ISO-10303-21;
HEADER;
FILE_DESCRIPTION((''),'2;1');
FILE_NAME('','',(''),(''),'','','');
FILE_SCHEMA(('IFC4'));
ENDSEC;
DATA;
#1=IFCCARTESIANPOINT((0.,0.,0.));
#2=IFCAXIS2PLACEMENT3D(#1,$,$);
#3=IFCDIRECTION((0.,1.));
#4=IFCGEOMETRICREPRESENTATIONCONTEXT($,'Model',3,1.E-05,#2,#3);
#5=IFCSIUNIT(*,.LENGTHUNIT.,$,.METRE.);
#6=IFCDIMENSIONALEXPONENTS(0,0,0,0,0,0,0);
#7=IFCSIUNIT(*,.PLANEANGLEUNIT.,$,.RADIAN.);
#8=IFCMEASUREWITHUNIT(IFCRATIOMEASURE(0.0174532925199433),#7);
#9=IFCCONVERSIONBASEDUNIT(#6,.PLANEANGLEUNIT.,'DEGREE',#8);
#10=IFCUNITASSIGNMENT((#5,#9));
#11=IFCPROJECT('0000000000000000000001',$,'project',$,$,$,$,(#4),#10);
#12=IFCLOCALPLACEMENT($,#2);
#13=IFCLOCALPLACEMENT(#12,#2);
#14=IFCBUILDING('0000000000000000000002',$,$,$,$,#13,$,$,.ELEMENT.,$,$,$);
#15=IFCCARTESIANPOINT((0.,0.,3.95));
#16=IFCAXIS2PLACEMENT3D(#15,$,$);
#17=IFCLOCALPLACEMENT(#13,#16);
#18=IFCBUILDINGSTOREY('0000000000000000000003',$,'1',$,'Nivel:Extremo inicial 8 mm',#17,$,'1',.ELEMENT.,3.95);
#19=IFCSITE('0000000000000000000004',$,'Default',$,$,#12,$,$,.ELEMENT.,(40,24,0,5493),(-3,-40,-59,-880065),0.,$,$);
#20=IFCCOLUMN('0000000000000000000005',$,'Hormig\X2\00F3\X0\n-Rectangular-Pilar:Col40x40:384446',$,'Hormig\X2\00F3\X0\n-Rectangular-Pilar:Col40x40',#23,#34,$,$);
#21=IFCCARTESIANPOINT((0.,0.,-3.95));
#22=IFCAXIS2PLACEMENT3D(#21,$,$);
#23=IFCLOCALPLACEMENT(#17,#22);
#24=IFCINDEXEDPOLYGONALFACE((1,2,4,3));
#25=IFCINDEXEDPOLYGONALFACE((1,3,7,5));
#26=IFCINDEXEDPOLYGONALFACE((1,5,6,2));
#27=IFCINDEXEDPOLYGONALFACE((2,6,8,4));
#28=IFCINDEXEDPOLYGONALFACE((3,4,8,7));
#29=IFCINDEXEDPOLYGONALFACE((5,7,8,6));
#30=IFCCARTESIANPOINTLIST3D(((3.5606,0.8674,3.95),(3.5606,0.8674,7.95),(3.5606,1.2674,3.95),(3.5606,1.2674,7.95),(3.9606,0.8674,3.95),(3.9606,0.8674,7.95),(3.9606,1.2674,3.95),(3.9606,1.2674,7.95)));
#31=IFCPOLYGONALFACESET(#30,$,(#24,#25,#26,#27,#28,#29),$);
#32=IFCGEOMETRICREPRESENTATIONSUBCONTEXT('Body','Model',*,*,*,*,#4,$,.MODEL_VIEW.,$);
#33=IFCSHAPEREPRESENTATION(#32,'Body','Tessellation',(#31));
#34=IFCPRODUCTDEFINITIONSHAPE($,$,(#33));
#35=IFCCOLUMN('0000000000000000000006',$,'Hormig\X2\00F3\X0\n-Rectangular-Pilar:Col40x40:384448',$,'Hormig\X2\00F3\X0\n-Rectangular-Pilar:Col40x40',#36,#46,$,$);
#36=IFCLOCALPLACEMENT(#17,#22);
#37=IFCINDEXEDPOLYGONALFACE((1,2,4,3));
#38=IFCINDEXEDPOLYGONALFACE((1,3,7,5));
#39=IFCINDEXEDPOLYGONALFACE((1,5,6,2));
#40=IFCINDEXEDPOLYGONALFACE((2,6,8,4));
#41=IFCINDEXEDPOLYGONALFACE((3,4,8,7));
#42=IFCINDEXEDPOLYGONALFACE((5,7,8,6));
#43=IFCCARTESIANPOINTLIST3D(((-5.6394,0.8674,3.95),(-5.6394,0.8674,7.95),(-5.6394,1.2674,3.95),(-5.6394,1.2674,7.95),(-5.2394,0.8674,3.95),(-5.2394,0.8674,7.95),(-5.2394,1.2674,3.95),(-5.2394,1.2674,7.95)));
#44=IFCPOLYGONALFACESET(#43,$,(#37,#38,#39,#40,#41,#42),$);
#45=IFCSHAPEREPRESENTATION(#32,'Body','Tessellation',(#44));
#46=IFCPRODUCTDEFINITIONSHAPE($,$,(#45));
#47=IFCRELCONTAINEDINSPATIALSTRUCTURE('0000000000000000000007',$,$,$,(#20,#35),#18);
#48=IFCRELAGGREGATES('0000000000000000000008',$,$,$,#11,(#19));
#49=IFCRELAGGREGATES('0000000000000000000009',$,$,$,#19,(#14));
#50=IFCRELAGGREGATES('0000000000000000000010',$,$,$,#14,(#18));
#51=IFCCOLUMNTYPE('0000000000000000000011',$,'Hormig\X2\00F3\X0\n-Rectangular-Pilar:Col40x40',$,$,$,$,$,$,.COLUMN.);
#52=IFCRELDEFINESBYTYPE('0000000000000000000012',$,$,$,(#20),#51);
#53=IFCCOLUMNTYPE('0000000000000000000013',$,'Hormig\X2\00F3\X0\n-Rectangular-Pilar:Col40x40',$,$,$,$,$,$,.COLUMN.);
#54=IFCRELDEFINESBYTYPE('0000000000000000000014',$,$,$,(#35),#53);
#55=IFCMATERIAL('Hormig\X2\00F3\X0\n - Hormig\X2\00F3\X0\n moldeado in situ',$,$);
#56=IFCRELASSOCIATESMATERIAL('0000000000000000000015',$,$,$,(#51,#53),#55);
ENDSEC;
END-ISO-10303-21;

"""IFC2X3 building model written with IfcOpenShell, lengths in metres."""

from ifc_helpers import new_model, entity, si_unit, converted_unit, direction, frame, origin, origin_2d_with_axis, place, context, subcontext, project, spatial, rectangle, extrude, source, transform, mapped, material, type_object, type_shapes, element, save


model = new_model("IFC2X3")

# Units and contexts
model_context = context("Model", 3, precision=1e-05, world=origin(), true_north=direction((0.0, 1.0)))
body_context = subcontext(model_context, "Body", "Model", "MODEL_VIEW")
ifc_project = project(units=[si_unit("LENGTHUNIT", "METRE"), converted_unit("PLANEANGLEUNIT", "DEGREE", entity("IfcRatioMeasure", 0.0174532925199433), si_unit("PLANEANGLEUNIT", "RADIAN"), dimensions=[0, 0, 0, 0, 0, 0, 0])], contexts=[model_context])

# Site, building, storey
site_placement = place(None, origin())
site = spatial("IfcSite", under=ifc_project, at=site_placement, Name="Default", CompositionType="ELEMENT", RefLatitude=(40, 24, 0, 5493), RefLongitude=(-3, -40, -59, -880065), RefElevation=0.0)
building_placement = place(site_placement, origin())
building = spatial("IfcBuilding", under=site, at=building_placement, CompositionType="ELEMENT")
storey_placement = place(building_placement, frame((0.0, 0.0, 3.95)))
storey = spatial("IfcBuildingStorey", under=building, at=storey_placement, Name="1", ObjectType="Nivel:Extremo inicial 8 mm", LongName="1", CompositionType="ELEMENT", Elevation=3.95)

# Columns
ifc_material_1 = material(Name="Hormigón - Hormigón moldeado in situ")
column_type_1 = type_object("IfcColumnType", Name="Hormigón-Rectangular-Pilar:Col40x40", PredefinedType="COLUMN", material=ifc_material_1)
shared_shape_1 = source(origin(), body_context, "Body", "SweptSolid", [
    extrude(rectangle(XDim=0.4, YDim=0.4, at=origin_2d_with_axis()), frame((3.7606, 1.0674, 3.95), z_axis=(0.0, 0.0, 1.0), x_axis=(0.0, -1.0, 0.0)), (0.0, 0.0, 1.0), 4.0),
])
type_shapes(column_type_1, [shared_shape_1])
column_1_placement = place(storey_placement, frame((0.0, 0.0, -3.95)))
element("IfcColumn", 1, at=column_1_placement, inside=storey, type_object=column_type_1, Name="Hormigón-Rectangular-Pilar:Col40x40:384446", ObjectType="Hormigón-Rectangular-Pilar:Col40x40", context=body_context, shape_type="MappedRepresentation", body=[
    mapped(shared_shape_1, transform((0.0, 0.0, 0.0), scale=1.0)),
])
column_type_2 = type_object("IfcColumnType", Name="Hormigón-Rectangular-Pilar:Col40x40", PredefinedType="COLUMN", material=ifc_material_1)
shared_shape_2 = source(origin(), body_context, "Body", "SweptSolid", [
    extrude(rectangle(XDim=0.4, YDim=0.4, at=origin_2d_with_axis()), frame((-5.4394, 1.0674, 3.95), z_axis=(0.0, 0.0, 1.0), x_axis=(0.0, -1.0, 0.0)), (0.0, 0.0, 1.0), 4.0),
])
type_shapes(column_type_2, [shared_shape_2])
column_2_placement = place(storey_placement, frame((0.0, 0.0, -3.95)))
element("IfcColumn", 2, at=column_2_placement, inside=storey, type_object=column_type_2, Name="Hormigón-Rectangular-Pilar:Col40x40:384448", ObjectType="Hormigón-Rectangular-Pilar:Col40x40", context=body_context, shape_type="MappedRepresentation", body=[
    mapped(shared_shape_2, transform((0.0, 0.0, 0.0), scale=1.0)),
])

save(model, "model.ifc")
